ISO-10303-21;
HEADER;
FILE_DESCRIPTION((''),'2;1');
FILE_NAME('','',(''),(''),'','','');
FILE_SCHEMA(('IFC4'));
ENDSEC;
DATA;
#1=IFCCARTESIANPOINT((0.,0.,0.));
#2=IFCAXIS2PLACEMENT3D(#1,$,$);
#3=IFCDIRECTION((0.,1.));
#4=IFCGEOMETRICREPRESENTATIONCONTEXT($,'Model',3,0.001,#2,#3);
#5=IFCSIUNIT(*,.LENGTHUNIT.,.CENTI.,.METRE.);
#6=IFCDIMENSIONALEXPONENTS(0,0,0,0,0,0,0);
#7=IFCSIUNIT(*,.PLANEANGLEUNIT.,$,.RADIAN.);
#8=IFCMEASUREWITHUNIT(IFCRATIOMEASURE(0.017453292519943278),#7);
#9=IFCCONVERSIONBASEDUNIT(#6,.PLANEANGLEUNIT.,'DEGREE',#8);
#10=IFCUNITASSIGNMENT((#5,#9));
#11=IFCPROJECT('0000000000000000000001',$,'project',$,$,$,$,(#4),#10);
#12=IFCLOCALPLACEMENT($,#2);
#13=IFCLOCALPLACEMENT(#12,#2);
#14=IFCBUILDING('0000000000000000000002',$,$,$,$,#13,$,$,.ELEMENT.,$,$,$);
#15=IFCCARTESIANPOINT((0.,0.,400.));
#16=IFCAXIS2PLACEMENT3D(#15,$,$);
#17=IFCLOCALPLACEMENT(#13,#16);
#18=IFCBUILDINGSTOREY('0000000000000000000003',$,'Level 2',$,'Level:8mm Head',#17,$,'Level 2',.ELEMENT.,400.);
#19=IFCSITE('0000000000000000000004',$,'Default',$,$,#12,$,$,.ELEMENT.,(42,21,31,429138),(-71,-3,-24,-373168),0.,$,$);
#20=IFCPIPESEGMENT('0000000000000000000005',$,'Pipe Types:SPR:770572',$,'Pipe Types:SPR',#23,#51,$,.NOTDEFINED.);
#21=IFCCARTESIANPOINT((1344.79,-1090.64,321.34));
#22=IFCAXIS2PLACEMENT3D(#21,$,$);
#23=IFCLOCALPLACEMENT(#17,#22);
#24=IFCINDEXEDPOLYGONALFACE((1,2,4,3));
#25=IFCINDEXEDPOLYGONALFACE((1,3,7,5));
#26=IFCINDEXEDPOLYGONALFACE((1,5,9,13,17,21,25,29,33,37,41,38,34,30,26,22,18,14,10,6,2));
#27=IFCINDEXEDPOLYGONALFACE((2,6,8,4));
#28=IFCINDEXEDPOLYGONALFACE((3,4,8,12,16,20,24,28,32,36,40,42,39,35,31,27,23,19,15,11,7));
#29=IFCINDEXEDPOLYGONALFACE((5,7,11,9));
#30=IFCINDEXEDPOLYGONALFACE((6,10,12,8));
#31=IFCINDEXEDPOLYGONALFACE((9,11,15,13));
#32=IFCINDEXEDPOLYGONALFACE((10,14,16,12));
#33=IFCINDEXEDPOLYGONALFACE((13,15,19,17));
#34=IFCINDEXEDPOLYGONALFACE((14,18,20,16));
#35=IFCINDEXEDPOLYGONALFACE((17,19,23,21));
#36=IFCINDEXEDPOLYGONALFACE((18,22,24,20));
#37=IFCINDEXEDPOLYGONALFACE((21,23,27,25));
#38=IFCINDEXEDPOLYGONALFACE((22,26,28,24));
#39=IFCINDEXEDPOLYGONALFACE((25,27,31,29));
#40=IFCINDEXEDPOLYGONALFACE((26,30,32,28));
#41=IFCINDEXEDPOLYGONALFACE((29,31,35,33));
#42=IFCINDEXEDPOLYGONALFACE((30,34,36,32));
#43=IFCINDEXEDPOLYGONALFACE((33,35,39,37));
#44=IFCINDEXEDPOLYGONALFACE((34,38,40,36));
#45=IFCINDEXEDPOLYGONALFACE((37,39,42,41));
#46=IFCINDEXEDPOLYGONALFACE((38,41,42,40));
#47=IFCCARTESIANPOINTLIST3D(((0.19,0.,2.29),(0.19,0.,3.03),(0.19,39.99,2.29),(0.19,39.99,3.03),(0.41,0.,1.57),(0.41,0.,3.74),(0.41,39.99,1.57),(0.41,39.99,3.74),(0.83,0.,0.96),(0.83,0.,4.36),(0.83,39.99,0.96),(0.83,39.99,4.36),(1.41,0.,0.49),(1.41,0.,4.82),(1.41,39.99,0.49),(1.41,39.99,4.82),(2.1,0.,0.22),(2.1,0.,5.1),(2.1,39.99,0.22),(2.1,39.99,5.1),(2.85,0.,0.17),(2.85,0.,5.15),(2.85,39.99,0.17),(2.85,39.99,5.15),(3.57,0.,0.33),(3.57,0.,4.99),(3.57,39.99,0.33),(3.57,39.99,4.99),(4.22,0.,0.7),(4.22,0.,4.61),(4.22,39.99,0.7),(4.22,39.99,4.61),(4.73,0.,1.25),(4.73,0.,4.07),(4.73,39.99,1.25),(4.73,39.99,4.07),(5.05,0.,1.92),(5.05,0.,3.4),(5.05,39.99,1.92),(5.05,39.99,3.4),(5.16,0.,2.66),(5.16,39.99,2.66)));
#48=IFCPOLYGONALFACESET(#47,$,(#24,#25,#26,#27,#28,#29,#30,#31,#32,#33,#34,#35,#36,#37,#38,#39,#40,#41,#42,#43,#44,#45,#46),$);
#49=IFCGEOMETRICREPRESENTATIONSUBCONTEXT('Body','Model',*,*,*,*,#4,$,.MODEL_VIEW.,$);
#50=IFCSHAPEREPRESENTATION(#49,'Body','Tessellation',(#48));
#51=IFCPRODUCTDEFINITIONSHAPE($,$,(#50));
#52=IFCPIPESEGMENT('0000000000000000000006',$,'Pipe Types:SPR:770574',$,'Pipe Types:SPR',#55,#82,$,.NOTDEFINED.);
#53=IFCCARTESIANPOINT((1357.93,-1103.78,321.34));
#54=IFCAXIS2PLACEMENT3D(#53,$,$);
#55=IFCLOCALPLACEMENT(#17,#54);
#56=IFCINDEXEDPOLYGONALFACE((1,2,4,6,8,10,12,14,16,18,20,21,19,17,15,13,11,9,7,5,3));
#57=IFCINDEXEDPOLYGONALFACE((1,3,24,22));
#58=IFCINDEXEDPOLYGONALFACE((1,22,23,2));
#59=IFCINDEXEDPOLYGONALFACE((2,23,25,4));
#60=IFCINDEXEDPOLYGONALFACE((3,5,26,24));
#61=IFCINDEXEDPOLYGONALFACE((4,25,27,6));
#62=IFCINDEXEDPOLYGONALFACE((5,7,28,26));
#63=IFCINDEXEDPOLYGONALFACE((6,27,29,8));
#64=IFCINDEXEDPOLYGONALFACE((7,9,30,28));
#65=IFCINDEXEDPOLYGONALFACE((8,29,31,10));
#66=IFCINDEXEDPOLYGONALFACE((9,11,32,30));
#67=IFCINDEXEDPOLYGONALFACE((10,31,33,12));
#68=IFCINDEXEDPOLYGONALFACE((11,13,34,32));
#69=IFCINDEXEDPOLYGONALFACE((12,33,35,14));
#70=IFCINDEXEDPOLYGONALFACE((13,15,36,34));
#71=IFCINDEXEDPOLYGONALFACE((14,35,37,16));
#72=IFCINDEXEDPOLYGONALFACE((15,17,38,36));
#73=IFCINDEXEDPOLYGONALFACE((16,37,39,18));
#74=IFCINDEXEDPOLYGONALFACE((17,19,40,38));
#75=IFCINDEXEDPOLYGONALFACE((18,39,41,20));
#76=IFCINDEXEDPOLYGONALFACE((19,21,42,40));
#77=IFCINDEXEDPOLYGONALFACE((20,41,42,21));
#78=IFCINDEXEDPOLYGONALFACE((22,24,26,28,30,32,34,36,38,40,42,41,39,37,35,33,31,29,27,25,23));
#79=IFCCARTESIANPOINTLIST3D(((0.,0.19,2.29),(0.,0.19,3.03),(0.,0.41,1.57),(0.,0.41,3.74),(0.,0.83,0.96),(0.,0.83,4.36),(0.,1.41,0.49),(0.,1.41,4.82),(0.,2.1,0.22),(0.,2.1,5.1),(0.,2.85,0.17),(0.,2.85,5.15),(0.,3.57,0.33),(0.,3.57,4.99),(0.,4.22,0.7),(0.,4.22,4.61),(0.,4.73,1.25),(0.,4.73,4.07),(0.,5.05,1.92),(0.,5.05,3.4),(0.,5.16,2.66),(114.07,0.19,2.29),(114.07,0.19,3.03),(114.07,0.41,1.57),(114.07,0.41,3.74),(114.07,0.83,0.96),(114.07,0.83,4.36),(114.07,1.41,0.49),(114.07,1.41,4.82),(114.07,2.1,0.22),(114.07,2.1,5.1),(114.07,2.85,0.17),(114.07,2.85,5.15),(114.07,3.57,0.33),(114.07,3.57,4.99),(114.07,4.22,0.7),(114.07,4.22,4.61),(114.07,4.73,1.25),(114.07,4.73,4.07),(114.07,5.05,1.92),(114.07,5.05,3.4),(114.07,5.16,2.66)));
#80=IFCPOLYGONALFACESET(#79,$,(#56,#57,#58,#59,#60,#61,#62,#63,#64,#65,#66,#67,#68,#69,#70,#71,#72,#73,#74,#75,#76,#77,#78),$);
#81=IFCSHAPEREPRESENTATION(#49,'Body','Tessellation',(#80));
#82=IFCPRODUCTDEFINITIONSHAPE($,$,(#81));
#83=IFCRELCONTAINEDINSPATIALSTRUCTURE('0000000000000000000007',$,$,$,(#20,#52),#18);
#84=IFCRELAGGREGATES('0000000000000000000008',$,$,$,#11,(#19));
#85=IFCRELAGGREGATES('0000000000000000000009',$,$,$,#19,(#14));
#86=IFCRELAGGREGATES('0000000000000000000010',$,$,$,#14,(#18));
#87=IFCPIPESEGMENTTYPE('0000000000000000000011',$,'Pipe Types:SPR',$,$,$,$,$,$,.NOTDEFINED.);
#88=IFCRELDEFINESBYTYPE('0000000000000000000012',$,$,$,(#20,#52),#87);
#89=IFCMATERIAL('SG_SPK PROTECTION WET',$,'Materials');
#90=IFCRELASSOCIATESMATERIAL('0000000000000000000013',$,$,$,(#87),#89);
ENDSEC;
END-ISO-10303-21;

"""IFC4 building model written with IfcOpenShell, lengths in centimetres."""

from ifc_helpers import new_model, entity, si_unit, converted_unit, direction, frame, frame_2d, origin, origin_2d_with_axis, place, context, subcontext, project, spatial, circle, extrude, material, type_object, element, save


model = new_model("IFC4")

# Units and contexts
model_context = context("Model", 3, precision=0.001, world=origin(), true_north=direction((0.0, 1.0)))
body_context = subcontext(model_context, "Body", "Model", "MODEL_VIEW")
ifc_project = project(units=[si_unit("LENGTHUNIT", "METRE", prefix="CENTI"), converted_unit("PLANEANGLEUNIT", "DEGREE", entity("IfcRatioMeasure", 0.017453292519943278), si_unit("PLANEANGLEUNIT", "RADIAN"), dimensions=[0, 0, 0, 0, 0, 0, 0])], contexts=[model_context])

# Site, building, storey
site_placement = place(None, origin())
site = spatial("IfcSite", under=ifc_project, at=site_placement, Name="Default", CompositionType="ELEMENT", RefLatitude=(42, 21, 31, 429138), RefLongitude=(-71, -3, -24, -373168), RefElevation=0.0)
building_placement = place(site_placement, origin())
building = spatial("IfcBuilding", under=site, at=building_placement, CompositionType="ELEMENT")
storey_placement = place(building_placement, frame((0.0, 0.0, 400.0)))
storey = spatial("IfcBuildingStorey", under=building, at=storey_placement, Name="Level 2", ObjectType="Level:8mm Head", LongName="Level 2", CompositionType="ELEMENT", Elevation=400.0)

# Pipe segments
ifc_material = material(Name="SG_SPK PROTECTION WET", Category="Materials")
pipe_segment_type = type_object("IfcPipeSegmentType", Name="Pipe Types:SPR", PredefinedType="NOTDEFINED", material=ifc_material)
pipe_segment_1_placement = place(storey_placement, frame((1344.79, -1090.64, 321.34)))
element("IfcPipeSegment", 1, at=pipe_segment_1_placement, inside=storey, type_object=pipe_segment_type, Name="Pipe Types:SPR:770572", ObjectType="Pipe Types:SPR", PredefinedType="NOTDEFINED", context=body_context, shape_type="SweptSolid", body=[
    extrude(circle(Radius=2.5, at=frame_2d((0.0, 0.0), x_axis=(1.0, 0.0))), frame((2.66, 0.0, 2.66), z_axis=(0.0, 1.0, 0.0), x_axis=(1.0, 0.0, 0.0)), (0.0, 0.0, 1.0), 39.99),
])
pipe_segment_2_placement = place(storey_placement, frame((1357.93, -1103.78, 321.34)))
element("IfcPipeSegment", 2, at=pipe_segment_2_placement, inside=storey, type_object=pipe_segment_type, Name="Pipe Types:SPR:770574", ObjectType="Pipe Types:SPR", PredefinedType="NOTDEFINED", context=body_context, shape_type="SweptSolid", body=[
    extrude(circle(Radius=2.5, at=origin_2d_with_axis()), frame((0.0, 2.66, 2.66), z_axis=(1.0, 0.0, 0.0), x_axis=(0.0, 1.0, 0.0)), (0.0, 0.0, 1.0), 114.07),
])

save(model, "model.ifc")
